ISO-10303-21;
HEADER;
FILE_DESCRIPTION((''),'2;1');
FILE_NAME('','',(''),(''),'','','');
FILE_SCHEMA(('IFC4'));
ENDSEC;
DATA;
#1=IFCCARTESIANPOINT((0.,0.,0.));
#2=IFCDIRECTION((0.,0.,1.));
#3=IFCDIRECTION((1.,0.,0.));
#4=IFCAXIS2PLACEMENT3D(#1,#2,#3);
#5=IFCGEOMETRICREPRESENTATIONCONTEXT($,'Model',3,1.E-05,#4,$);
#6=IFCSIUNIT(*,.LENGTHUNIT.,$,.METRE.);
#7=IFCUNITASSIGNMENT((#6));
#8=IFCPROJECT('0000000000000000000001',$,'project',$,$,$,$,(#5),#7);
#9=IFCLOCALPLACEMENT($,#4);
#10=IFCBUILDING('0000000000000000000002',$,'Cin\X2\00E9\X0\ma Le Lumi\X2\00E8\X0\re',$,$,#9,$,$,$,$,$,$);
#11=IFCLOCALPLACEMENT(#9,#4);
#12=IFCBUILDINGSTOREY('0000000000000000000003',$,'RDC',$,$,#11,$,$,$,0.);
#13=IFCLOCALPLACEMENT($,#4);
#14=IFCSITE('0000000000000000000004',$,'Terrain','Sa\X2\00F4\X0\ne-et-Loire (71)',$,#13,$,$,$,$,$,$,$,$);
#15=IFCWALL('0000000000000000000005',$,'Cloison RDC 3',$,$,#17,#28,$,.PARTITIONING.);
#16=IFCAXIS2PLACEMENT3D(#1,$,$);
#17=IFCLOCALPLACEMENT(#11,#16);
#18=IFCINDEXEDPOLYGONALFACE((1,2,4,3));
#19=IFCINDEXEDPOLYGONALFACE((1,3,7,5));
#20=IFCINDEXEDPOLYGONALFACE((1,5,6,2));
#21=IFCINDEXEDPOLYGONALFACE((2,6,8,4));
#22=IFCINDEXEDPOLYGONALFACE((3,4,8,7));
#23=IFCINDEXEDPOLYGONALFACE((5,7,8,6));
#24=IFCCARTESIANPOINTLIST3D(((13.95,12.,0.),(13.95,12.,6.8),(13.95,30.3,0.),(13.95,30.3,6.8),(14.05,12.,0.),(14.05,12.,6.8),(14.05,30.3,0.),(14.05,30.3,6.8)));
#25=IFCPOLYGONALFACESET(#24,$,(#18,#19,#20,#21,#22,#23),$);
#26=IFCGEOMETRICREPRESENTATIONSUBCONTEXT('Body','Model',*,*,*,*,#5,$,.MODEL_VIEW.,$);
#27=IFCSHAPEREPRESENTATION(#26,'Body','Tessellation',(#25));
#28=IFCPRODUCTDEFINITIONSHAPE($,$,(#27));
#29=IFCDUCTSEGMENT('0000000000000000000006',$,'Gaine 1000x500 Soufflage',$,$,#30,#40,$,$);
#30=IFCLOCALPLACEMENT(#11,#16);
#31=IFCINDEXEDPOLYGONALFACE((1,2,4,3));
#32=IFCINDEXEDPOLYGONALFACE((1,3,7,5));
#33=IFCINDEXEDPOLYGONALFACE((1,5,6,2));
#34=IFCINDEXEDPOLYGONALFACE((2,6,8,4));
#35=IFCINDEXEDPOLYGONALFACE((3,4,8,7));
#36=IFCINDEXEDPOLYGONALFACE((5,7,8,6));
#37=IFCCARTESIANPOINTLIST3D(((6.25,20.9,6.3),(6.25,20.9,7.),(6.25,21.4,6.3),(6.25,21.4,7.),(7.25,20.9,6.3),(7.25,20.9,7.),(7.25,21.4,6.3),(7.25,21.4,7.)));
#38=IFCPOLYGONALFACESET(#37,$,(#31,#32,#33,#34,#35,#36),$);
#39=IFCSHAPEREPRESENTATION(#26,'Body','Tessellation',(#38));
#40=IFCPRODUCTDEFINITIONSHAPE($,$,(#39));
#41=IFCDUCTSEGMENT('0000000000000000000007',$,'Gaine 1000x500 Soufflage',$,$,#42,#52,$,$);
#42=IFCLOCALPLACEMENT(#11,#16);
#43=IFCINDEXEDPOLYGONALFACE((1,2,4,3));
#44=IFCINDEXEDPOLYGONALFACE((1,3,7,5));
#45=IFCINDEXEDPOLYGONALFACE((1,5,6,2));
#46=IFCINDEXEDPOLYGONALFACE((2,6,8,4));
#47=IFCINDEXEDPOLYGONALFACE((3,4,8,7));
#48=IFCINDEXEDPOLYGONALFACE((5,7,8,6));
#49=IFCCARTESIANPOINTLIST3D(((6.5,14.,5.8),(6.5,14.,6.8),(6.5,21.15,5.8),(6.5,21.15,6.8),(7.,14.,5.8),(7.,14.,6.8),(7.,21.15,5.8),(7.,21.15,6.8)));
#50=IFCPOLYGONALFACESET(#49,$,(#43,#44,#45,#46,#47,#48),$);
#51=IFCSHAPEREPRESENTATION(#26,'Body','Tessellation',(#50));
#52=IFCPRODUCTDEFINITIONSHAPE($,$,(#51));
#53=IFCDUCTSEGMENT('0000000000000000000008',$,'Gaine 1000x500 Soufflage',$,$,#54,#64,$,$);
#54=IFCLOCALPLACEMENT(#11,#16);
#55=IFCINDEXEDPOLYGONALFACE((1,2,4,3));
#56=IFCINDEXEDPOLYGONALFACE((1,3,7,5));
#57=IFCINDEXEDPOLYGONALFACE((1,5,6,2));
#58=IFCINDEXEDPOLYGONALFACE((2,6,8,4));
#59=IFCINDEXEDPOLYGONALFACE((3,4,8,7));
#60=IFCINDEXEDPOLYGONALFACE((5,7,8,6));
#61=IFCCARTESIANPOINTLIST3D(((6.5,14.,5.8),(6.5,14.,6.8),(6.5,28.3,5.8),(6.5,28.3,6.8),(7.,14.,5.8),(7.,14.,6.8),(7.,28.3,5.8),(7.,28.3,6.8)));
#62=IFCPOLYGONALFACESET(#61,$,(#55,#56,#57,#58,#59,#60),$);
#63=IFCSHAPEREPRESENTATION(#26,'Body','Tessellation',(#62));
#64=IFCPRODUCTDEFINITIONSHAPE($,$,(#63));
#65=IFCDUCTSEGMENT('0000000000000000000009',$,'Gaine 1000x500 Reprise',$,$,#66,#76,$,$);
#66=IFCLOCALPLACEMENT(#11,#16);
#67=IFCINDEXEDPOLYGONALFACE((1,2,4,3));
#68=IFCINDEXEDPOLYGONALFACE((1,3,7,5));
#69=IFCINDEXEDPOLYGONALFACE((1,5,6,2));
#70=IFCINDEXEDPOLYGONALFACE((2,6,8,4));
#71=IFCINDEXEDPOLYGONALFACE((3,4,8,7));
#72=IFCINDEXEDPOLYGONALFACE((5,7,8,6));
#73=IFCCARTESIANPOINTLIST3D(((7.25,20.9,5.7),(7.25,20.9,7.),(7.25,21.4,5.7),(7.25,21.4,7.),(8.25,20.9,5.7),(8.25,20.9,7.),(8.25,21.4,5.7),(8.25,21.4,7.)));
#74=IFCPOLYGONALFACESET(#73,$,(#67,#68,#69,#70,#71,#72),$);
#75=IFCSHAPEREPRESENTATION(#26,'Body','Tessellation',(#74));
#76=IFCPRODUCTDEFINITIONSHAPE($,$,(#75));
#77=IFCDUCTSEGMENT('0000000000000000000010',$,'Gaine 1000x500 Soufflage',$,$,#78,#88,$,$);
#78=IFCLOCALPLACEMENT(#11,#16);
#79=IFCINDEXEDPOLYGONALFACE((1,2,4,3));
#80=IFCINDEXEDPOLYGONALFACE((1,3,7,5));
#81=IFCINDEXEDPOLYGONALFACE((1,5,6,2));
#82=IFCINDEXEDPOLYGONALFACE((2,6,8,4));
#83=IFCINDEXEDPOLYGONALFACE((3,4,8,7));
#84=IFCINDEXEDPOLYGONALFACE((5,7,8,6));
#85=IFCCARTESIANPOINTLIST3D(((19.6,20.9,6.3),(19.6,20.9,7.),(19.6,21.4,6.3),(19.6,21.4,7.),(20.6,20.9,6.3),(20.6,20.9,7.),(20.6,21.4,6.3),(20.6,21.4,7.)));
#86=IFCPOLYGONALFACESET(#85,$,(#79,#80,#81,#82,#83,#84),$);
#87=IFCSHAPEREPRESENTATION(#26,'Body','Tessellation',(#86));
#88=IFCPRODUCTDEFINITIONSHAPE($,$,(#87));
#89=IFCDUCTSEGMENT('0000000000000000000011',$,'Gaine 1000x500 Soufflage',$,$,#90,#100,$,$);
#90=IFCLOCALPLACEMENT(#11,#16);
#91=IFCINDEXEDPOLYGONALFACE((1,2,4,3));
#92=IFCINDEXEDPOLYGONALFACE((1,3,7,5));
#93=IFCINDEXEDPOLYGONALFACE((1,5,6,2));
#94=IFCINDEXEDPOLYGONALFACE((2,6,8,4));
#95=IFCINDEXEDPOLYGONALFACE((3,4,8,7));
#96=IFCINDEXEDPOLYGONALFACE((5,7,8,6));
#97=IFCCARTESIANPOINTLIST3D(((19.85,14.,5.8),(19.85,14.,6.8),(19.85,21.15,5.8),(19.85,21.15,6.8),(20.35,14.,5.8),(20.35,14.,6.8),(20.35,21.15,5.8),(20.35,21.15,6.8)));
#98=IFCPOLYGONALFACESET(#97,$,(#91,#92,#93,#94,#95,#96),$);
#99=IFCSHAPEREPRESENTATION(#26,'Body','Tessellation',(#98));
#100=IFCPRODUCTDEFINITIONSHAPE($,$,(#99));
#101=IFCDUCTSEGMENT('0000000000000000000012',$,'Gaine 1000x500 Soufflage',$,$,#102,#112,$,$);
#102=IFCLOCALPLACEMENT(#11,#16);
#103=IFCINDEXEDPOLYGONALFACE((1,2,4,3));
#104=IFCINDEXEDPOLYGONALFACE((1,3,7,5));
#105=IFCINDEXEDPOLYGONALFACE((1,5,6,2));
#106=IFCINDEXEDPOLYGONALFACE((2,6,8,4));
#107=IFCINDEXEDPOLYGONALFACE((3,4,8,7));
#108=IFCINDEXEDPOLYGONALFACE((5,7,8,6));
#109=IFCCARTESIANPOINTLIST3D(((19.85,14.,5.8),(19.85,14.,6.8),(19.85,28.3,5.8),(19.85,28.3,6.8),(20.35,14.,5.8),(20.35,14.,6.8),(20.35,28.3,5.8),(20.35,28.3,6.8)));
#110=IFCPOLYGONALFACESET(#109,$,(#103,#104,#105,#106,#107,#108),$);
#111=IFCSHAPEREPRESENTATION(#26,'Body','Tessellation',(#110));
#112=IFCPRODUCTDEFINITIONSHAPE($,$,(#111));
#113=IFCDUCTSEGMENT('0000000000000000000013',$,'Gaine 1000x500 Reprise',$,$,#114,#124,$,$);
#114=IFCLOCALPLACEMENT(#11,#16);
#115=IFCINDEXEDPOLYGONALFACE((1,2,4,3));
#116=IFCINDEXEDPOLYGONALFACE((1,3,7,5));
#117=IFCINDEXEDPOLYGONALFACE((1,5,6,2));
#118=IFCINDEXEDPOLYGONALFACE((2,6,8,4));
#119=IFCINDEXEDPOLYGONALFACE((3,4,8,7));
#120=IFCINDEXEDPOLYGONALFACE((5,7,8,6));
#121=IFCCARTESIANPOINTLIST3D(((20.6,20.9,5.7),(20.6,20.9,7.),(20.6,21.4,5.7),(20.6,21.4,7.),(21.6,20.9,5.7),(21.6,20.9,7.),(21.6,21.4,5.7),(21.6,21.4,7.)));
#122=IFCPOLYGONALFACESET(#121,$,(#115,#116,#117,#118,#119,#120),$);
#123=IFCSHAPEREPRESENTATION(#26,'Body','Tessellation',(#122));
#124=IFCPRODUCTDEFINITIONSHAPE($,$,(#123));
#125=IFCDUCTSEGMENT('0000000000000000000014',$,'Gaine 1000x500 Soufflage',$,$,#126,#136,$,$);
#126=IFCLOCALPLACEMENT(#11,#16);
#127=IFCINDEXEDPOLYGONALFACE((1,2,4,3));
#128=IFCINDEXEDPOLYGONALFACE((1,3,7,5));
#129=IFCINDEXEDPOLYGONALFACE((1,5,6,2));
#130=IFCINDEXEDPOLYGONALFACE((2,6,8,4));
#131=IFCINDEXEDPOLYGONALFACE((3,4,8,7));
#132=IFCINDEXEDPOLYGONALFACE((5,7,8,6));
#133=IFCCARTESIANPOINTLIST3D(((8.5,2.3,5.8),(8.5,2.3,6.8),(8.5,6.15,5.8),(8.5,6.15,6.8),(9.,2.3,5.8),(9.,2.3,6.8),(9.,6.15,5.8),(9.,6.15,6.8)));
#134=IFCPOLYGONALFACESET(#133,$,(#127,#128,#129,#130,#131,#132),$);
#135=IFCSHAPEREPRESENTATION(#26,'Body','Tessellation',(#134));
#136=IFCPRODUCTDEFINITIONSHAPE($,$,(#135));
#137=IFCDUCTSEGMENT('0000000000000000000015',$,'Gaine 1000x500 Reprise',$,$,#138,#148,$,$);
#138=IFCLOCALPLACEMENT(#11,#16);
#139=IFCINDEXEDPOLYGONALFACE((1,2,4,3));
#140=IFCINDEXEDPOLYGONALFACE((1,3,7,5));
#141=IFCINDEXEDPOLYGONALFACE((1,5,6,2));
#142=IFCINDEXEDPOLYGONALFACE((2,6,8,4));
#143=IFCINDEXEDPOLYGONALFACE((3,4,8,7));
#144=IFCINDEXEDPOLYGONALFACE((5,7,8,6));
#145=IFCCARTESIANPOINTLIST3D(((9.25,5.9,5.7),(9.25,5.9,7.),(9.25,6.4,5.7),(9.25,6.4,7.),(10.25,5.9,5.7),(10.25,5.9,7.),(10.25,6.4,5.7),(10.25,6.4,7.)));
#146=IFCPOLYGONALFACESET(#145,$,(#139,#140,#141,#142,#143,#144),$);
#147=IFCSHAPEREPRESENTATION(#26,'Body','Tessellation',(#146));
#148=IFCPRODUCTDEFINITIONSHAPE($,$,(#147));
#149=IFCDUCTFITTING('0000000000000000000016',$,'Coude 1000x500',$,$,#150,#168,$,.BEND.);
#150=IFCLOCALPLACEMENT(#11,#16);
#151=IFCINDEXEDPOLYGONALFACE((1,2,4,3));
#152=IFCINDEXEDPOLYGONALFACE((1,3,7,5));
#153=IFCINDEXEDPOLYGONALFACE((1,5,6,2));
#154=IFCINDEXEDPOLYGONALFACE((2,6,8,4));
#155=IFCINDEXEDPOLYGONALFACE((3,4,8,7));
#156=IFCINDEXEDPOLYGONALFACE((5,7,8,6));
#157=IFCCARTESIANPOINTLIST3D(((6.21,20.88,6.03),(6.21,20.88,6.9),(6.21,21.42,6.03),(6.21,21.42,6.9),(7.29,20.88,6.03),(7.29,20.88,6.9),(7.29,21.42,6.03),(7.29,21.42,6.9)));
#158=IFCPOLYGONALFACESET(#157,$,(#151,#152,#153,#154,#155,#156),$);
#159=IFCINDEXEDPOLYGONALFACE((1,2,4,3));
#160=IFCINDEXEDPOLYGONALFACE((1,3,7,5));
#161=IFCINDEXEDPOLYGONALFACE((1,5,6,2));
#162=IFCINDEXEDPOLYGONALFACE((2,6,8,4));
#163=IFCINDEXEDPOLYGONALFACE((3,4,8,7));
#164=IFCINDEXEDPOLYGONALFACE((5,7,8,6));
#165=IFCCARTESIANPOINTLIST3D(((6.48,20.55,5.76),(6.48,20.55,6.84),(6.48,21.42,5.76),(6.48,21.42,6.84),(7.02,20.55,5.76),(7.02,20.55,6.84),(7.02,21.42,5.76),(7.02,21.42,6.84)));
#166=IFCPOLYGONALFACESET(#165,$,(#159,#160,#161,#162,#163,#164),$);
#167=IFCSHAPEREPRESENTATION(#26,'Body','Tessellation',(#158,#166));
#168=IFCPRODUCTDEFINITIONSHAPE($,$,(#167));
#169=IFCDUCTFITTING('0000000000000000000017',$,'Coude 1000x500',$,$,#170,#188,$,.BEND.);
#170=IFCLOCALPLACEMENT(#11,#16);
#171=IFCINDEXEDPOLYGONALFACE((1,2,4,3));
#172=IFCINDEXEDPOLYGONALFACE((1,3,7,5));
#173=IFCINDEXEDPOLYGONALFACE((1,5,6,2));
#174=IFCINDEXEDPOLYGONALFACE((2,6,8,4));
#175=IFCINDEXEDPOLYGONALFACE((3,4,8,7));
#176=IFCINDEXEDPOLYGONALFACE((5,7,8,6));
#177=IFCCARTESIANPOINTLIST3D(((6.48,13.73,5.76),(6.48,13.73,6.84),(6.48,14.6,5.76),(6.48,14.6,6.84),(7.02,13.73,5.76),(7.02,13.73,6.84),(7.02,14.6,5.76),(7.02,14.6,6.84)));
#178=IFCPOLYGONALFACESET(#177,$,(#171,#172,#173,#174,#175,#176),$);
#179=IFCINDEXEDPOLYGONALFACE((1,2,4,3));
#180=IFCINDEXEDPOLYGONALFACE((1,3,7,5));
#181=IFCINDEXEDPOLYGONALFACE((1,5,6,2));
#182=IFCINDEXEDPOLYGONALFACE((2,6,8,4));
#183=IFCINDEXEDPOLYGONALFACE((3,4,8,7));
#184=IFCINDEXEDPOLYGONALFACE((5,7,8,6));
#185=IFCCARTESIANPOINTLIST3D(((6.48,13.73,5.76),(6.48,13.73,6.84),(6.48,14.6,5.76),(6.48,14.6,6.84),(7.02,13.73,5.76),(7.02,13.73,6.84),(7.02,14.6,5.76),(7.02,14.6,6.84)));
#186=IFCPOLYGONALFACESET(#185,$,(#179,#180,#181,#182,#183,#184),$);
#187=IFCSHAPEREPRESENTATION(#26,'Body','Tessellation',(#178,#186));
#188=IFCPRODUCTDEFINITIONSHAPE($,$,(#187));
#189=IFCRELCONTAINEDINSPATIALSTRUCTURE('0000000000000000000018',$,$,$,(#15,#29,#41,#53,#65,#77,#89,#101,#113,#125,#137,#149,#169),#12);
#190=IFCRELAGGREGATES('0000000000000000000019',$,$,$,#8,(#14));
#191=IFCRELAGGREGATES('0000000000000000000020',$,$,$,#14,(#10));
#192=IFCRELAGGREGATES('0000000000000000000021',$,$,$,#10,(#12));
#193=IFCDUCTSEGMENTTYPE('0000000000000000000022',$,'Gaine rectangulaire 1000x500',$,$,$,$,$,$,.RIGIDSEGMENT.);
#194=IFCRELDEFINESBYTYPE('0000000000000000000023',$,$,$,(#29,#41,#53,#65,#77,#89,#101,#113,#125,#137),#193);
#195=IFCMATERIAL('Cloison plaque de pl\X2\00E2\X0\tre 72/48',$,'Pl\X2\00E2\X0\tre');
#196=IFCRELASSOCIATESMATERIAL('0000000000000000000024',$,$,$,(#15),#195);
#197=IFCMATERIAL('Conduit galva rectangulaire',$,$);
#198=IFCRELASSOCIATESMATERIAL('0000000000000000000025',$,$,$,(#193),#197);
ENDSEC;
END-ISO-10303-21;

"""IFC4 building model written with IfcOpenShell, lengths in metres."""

from ifc_helpers import new_model, si_unit, frame, frame_2d, origin_with_axes, origin_2d, place, context, subcontext, project, spatial, rectangle, extrude, material, type_object, element, save


model = new_model("IFC4")

# Units and contexts
model_context = context("Model", 3, precision=1e-05, world=origin_with_axes())
body_context = subcontext(model_context, "Body", "Model", "MODEL_VIEW")
ifc_project = project(units=[si_unit("LENGTHUNIT", "METRE")], contexts=[model_context])

# Site, building, storey
site_placement = place(None, origin_with_axes())
site = spatial("IfcSite", under=ifc_project, at=site_placement, Name="Terrain", Description="Saône-et-Loire (71)")
building_placement = place(None, origin_with_axes())
building = spatial("IfcBuilding", under=site, at=building_placement, Name="Cinéma Le Lumière")
storey_placement = place(building_placement, origin_with_axes())
storey = spatial("IfcBuildingStorey", under=building, at=storey_placement, Name="RDC", Elevation=0.0)

# Shared definitions
ifc_material_1 = material(Name="Cloison plaque de plâtre 72/48", Category="Plâtre")

# Wall
wall_1_placement = place(storey_placement, frame((13.95, 12.0, 0.0), z_axis=(0.0, 0.0, 1.0), x_axis=(1.0, 0.0, 0.0)))
element("IfcWall", 1, at=wall_1_placement, inside=storey, material=ifc_material_1, Name="Cloison RDC 3", PredefinedType="PARTITIONING", context=body_context, shape_type="SweptSolid", body=[
    extrude(rectangle(XDim=0.1, YDim=18.3, at=frame_2d((0.05, 9.15))), origin_with_axes(), (0.0, 0.0, 1.0), 6.8),
])

# Duct segments
ifc_material_2 = material(Name="Conduit galva rectangulaire")
duct_segment_type = type_object("IfcDuctSegmentType", Name="Gaine rectangulaire 1000x500", PredefinedType="RIGIDSEGMENT", material=ifc_material_2)
duct_segment_1_placement = place(storey_placement, frame((6.75, 21.15, 7.0), z_axis=(0.0, 0.0, -1.0), x_axis=(1.0, 0.0, 0.0)))
element("IfcDuctSegment", 2, at=duct_segment_1_placement, inside=storey, type_object=duct_segment_type, Name="Gaine 1000x500 Soufflage", context=body_context, shape_type="SweptSolid", body=[
    extrude(rectangle(XDim=1.0, YDim=0.5, at=origin_2d()), origin_with_axes(), (0.0, 0.0, 1.0), 0.7),
])
duct_segment_2_placement = place(storey_placement, frame((6.75, 21.15, 6.3), z_axis=(0.0, -1.0, 0.0), x_axis=(0.0, 0.0, 1.0)))
element("IfcDuctSegment", 3, at=duct_segment_2_placement, inside=storey, type_object=duct_segment_type, Name="Gaine 1000x500 Soufflage", context=body_context, shape_type="SweptSolid", body=[
    extrude(rectangle(XDim=1.0, YDim=0.5, at=origin_2d()), origin_with_axes(), (0.0, 0.0, 1.0), 7.15),
])
duct_segment_3_placement = place(storey_placement, frame((6.75, 14.0, 6.3), z_axis=(0.0, 1.0, 0.0), x_axis=(0.0, 0.0, 1.0)))
element("IfcDuctSegment", 4, at=duct_segment_3_placement, inside=storey, type_object=duct_segment_type, Name="Gaine 1000x500 Soufflage", context=body_context, shape_type="SweptSolid", body=[
    extrude(rectangle(XDim=1.0, YDim=0.5, at=origin_2d()), origin_with_axes(), (0.0, 0.0, 1.0), 14.3),
])
duct_segment_4_placement = place(storey_placement, frame((7.75, 21.15, 7.0), z_axis=(0.0, 0.0, -1.0), x_axis=(1.0, 0.0, 0.0)))
element("IfcDuctSegment", 5, at=duct_segment_4_placement, inside=storey, type_object=duct_segment_type, Name="Gaine 1000x500 Reprise", context=body_context, shape_type="SweptSolid", body=[
    extrude(rectangle(XDim=1.0, YDim=0.5, at=origin_2d()), origin_with_axes(), (0.0, 0.0, 1.0), 1.3),
])
duct_segment_5_placement = place(storey_placement, frame((20.1, 21.15, 7.0), z_axis=(0.0, 0.0, -1.0), x_axis=(1.0, 0.0, 0.0)))
element("IfcDuctSegment", 6, at=duct_segment_5_placement, inside=storey, type_object=duct_segment_type, Name="Gaine 1000x500 Soufflage", context=body_context, shape_type="SweptSolid", body=[
    extrude(rectangle(XDim=1.0, YDim=0.5, at=origin_2d()), origin_with_axes(), (0.0, 0.0, 1.0), 0.7),
])
duct_segment_6_placement = place(storey_placement, frame((20.1, 21.15, 6.3), z_axis=(0.0, -1.0, 0.0), x_axis=(0.0, 0.0, 1.0)))
element("IfcDuctSegment", 7, at=duct_segment_6_placement, inside=storey, type_object=duct_segment_type, Name="Gaine 1000x500 Soufflage", context=body_context, shape_type="SweptSolid", body=[
    extrude(rectangle(XDim=1.0, YDim=0.5, at=origin_2d()), origin_with_axes(), (0.0, 0.0, 1.0), 7.15),
])
duct_segment_7_placement = place(storey_placement, frame((20.1, 14.0, 6.3), z_axis=(0.0, 1.0, 0.0), x_axis=(0.0, 0.0, 1.0)))
element("IfcDuctSegment", 8, at=duct_segment_7_placement, inside=storey, type_object=duct_segment_type, Name="Gaine 1000x500 Soufflage", context=body_context, shape_type="SweptSolid", body=[
    extrude(rectangle(XDim=1.0, YDim=0.5, at=origin_2d()), origin_with_axes(), (0.0, 0.0, 1.0), 14.3),
])
duct_segment_8_placement = place(storey_placement, frame((21.1, 21.15, 7.0), z_axis=(0.0, 0.0, -1.0), x_axis=(1.0, 0.0, 0.0)))
element("IfcDuctSegment", 9, at=duct_segment_8_placement, inside=storey, type_object=duct_segment_type, Name="Gaine 1000x500 Reprise", context=body_context, shape_type="SweptSolid", body=[
    extrude(rectangle(XDim=1.0, YDim=0.5, at=origin_2d()), origin_with_axes(), (0.0, 0.0, 1.0), 1.3),
])
duct_segment_9_placement = place(storey_placement, frame((8.75, 6.15, 6.3), z_axis=(0.0, -1.0, 0.0), x_axis=(0.0, 0.0, 1.0)))
element("IfcDuctSegment", 10, at=duct_segment_9_placement, inside=storey, type_object=duct_segment_type, Name="Gaine 1000x500 Soufflage", context=body_context, shape_type="SweptSolid", body=[
    extrude(rectangle(XDim=1.0, YDim=0.5, at=origin_2d()), origin_with_axes(), (0.0, 0.0, 1.0), 3.85),
])
duct_segment_10_placement = place(storey_placement, frame((9.75, 6.15, 7.0), z_axis=(0.0, 0.0, -1.0), x_axis=(1.0, 0.0, 0.0)))
element("IfcDuctSegment", 11, at=duct_segment_10_placement, inside=storey, type_object=duct_segment_type, Name="Gaine 1000x500 Reprise", context=body_context, shape_type="SweptSolid", body=[
    extrude(rectangle(XDim=1.0, YDim=0.5, at=origin_2d()), origin_with_axes(), (0.0, 0.0, 1.0), 1.3),
])

# Duct fittings
duct_fitting_1_placement = place(storey_placement, frame((6.75, 21.15, 6.3), z_axis=(0.0, 0.0, 1.0), x_axis=(1.0, 0.0, 0.0)))
element("IfcDuctFitting", 12, at=duct_fitting_1_placement, inside=storey, Name="Coude 1000x500", PredefinedType="BEND", context=body_context, shape_type="SweptSolid", body=[
    extrude(rectangle(XDim=1.08, YDim=0.54, at=origin_2d()), frame((0.0, 0.0, -0.27), z_axis=(0.0, 0.0, 1.0), x_axis=(1.0, 0.0, 0.0)), (0.0, 0.0, 1.0), 0.87),
    extrude(rectangle(XDim=1.08, YDim=0.54, at=origin_2d()), frame((0.0, 0.27, 0.0), z_axis=(0.0, -1.0, 0.0), x_axis=(0.0, 0.0, 1.0)), (0.0, 0.0, 1.0), 0.87),
])
duct_fitting_2_placement = place(storey_placement, frame((6.75, 14.0, 6.3), z_axis=(0.0, 0.0, 1.0), x_axis=(1.0, 0.0, 0.0)))
element("IfcDuctFitting", 13, at=duct_fitting_2_placement, inside=storey, Name="Coude 1000x500", PredefinedType="BEND", context=body_context, shape_type="SweptSolid", body=[
    extrude(rectangle(XDim=1.08, YDim=0.54, at=origin_2d()), frame((0.0, -0.27, 0.0), z_axis=(0.0, 1.0, 0.0), x_axis=(0.0, 0.0, 1.0)), (0.0, 0.0, 1.0), 0.87),
    extrude(rectangle(XDim=1.08, YDim=0.54, at=origin_2d()), frame((0.0, -0.27, 0.0), z_axis=(0.0, 1.0, 0.0), x_axis=(0.0, 0.0, 1.0)), (0.0, 0.0, 1.0), 0.87),
])

save(model, "model.ifc")
